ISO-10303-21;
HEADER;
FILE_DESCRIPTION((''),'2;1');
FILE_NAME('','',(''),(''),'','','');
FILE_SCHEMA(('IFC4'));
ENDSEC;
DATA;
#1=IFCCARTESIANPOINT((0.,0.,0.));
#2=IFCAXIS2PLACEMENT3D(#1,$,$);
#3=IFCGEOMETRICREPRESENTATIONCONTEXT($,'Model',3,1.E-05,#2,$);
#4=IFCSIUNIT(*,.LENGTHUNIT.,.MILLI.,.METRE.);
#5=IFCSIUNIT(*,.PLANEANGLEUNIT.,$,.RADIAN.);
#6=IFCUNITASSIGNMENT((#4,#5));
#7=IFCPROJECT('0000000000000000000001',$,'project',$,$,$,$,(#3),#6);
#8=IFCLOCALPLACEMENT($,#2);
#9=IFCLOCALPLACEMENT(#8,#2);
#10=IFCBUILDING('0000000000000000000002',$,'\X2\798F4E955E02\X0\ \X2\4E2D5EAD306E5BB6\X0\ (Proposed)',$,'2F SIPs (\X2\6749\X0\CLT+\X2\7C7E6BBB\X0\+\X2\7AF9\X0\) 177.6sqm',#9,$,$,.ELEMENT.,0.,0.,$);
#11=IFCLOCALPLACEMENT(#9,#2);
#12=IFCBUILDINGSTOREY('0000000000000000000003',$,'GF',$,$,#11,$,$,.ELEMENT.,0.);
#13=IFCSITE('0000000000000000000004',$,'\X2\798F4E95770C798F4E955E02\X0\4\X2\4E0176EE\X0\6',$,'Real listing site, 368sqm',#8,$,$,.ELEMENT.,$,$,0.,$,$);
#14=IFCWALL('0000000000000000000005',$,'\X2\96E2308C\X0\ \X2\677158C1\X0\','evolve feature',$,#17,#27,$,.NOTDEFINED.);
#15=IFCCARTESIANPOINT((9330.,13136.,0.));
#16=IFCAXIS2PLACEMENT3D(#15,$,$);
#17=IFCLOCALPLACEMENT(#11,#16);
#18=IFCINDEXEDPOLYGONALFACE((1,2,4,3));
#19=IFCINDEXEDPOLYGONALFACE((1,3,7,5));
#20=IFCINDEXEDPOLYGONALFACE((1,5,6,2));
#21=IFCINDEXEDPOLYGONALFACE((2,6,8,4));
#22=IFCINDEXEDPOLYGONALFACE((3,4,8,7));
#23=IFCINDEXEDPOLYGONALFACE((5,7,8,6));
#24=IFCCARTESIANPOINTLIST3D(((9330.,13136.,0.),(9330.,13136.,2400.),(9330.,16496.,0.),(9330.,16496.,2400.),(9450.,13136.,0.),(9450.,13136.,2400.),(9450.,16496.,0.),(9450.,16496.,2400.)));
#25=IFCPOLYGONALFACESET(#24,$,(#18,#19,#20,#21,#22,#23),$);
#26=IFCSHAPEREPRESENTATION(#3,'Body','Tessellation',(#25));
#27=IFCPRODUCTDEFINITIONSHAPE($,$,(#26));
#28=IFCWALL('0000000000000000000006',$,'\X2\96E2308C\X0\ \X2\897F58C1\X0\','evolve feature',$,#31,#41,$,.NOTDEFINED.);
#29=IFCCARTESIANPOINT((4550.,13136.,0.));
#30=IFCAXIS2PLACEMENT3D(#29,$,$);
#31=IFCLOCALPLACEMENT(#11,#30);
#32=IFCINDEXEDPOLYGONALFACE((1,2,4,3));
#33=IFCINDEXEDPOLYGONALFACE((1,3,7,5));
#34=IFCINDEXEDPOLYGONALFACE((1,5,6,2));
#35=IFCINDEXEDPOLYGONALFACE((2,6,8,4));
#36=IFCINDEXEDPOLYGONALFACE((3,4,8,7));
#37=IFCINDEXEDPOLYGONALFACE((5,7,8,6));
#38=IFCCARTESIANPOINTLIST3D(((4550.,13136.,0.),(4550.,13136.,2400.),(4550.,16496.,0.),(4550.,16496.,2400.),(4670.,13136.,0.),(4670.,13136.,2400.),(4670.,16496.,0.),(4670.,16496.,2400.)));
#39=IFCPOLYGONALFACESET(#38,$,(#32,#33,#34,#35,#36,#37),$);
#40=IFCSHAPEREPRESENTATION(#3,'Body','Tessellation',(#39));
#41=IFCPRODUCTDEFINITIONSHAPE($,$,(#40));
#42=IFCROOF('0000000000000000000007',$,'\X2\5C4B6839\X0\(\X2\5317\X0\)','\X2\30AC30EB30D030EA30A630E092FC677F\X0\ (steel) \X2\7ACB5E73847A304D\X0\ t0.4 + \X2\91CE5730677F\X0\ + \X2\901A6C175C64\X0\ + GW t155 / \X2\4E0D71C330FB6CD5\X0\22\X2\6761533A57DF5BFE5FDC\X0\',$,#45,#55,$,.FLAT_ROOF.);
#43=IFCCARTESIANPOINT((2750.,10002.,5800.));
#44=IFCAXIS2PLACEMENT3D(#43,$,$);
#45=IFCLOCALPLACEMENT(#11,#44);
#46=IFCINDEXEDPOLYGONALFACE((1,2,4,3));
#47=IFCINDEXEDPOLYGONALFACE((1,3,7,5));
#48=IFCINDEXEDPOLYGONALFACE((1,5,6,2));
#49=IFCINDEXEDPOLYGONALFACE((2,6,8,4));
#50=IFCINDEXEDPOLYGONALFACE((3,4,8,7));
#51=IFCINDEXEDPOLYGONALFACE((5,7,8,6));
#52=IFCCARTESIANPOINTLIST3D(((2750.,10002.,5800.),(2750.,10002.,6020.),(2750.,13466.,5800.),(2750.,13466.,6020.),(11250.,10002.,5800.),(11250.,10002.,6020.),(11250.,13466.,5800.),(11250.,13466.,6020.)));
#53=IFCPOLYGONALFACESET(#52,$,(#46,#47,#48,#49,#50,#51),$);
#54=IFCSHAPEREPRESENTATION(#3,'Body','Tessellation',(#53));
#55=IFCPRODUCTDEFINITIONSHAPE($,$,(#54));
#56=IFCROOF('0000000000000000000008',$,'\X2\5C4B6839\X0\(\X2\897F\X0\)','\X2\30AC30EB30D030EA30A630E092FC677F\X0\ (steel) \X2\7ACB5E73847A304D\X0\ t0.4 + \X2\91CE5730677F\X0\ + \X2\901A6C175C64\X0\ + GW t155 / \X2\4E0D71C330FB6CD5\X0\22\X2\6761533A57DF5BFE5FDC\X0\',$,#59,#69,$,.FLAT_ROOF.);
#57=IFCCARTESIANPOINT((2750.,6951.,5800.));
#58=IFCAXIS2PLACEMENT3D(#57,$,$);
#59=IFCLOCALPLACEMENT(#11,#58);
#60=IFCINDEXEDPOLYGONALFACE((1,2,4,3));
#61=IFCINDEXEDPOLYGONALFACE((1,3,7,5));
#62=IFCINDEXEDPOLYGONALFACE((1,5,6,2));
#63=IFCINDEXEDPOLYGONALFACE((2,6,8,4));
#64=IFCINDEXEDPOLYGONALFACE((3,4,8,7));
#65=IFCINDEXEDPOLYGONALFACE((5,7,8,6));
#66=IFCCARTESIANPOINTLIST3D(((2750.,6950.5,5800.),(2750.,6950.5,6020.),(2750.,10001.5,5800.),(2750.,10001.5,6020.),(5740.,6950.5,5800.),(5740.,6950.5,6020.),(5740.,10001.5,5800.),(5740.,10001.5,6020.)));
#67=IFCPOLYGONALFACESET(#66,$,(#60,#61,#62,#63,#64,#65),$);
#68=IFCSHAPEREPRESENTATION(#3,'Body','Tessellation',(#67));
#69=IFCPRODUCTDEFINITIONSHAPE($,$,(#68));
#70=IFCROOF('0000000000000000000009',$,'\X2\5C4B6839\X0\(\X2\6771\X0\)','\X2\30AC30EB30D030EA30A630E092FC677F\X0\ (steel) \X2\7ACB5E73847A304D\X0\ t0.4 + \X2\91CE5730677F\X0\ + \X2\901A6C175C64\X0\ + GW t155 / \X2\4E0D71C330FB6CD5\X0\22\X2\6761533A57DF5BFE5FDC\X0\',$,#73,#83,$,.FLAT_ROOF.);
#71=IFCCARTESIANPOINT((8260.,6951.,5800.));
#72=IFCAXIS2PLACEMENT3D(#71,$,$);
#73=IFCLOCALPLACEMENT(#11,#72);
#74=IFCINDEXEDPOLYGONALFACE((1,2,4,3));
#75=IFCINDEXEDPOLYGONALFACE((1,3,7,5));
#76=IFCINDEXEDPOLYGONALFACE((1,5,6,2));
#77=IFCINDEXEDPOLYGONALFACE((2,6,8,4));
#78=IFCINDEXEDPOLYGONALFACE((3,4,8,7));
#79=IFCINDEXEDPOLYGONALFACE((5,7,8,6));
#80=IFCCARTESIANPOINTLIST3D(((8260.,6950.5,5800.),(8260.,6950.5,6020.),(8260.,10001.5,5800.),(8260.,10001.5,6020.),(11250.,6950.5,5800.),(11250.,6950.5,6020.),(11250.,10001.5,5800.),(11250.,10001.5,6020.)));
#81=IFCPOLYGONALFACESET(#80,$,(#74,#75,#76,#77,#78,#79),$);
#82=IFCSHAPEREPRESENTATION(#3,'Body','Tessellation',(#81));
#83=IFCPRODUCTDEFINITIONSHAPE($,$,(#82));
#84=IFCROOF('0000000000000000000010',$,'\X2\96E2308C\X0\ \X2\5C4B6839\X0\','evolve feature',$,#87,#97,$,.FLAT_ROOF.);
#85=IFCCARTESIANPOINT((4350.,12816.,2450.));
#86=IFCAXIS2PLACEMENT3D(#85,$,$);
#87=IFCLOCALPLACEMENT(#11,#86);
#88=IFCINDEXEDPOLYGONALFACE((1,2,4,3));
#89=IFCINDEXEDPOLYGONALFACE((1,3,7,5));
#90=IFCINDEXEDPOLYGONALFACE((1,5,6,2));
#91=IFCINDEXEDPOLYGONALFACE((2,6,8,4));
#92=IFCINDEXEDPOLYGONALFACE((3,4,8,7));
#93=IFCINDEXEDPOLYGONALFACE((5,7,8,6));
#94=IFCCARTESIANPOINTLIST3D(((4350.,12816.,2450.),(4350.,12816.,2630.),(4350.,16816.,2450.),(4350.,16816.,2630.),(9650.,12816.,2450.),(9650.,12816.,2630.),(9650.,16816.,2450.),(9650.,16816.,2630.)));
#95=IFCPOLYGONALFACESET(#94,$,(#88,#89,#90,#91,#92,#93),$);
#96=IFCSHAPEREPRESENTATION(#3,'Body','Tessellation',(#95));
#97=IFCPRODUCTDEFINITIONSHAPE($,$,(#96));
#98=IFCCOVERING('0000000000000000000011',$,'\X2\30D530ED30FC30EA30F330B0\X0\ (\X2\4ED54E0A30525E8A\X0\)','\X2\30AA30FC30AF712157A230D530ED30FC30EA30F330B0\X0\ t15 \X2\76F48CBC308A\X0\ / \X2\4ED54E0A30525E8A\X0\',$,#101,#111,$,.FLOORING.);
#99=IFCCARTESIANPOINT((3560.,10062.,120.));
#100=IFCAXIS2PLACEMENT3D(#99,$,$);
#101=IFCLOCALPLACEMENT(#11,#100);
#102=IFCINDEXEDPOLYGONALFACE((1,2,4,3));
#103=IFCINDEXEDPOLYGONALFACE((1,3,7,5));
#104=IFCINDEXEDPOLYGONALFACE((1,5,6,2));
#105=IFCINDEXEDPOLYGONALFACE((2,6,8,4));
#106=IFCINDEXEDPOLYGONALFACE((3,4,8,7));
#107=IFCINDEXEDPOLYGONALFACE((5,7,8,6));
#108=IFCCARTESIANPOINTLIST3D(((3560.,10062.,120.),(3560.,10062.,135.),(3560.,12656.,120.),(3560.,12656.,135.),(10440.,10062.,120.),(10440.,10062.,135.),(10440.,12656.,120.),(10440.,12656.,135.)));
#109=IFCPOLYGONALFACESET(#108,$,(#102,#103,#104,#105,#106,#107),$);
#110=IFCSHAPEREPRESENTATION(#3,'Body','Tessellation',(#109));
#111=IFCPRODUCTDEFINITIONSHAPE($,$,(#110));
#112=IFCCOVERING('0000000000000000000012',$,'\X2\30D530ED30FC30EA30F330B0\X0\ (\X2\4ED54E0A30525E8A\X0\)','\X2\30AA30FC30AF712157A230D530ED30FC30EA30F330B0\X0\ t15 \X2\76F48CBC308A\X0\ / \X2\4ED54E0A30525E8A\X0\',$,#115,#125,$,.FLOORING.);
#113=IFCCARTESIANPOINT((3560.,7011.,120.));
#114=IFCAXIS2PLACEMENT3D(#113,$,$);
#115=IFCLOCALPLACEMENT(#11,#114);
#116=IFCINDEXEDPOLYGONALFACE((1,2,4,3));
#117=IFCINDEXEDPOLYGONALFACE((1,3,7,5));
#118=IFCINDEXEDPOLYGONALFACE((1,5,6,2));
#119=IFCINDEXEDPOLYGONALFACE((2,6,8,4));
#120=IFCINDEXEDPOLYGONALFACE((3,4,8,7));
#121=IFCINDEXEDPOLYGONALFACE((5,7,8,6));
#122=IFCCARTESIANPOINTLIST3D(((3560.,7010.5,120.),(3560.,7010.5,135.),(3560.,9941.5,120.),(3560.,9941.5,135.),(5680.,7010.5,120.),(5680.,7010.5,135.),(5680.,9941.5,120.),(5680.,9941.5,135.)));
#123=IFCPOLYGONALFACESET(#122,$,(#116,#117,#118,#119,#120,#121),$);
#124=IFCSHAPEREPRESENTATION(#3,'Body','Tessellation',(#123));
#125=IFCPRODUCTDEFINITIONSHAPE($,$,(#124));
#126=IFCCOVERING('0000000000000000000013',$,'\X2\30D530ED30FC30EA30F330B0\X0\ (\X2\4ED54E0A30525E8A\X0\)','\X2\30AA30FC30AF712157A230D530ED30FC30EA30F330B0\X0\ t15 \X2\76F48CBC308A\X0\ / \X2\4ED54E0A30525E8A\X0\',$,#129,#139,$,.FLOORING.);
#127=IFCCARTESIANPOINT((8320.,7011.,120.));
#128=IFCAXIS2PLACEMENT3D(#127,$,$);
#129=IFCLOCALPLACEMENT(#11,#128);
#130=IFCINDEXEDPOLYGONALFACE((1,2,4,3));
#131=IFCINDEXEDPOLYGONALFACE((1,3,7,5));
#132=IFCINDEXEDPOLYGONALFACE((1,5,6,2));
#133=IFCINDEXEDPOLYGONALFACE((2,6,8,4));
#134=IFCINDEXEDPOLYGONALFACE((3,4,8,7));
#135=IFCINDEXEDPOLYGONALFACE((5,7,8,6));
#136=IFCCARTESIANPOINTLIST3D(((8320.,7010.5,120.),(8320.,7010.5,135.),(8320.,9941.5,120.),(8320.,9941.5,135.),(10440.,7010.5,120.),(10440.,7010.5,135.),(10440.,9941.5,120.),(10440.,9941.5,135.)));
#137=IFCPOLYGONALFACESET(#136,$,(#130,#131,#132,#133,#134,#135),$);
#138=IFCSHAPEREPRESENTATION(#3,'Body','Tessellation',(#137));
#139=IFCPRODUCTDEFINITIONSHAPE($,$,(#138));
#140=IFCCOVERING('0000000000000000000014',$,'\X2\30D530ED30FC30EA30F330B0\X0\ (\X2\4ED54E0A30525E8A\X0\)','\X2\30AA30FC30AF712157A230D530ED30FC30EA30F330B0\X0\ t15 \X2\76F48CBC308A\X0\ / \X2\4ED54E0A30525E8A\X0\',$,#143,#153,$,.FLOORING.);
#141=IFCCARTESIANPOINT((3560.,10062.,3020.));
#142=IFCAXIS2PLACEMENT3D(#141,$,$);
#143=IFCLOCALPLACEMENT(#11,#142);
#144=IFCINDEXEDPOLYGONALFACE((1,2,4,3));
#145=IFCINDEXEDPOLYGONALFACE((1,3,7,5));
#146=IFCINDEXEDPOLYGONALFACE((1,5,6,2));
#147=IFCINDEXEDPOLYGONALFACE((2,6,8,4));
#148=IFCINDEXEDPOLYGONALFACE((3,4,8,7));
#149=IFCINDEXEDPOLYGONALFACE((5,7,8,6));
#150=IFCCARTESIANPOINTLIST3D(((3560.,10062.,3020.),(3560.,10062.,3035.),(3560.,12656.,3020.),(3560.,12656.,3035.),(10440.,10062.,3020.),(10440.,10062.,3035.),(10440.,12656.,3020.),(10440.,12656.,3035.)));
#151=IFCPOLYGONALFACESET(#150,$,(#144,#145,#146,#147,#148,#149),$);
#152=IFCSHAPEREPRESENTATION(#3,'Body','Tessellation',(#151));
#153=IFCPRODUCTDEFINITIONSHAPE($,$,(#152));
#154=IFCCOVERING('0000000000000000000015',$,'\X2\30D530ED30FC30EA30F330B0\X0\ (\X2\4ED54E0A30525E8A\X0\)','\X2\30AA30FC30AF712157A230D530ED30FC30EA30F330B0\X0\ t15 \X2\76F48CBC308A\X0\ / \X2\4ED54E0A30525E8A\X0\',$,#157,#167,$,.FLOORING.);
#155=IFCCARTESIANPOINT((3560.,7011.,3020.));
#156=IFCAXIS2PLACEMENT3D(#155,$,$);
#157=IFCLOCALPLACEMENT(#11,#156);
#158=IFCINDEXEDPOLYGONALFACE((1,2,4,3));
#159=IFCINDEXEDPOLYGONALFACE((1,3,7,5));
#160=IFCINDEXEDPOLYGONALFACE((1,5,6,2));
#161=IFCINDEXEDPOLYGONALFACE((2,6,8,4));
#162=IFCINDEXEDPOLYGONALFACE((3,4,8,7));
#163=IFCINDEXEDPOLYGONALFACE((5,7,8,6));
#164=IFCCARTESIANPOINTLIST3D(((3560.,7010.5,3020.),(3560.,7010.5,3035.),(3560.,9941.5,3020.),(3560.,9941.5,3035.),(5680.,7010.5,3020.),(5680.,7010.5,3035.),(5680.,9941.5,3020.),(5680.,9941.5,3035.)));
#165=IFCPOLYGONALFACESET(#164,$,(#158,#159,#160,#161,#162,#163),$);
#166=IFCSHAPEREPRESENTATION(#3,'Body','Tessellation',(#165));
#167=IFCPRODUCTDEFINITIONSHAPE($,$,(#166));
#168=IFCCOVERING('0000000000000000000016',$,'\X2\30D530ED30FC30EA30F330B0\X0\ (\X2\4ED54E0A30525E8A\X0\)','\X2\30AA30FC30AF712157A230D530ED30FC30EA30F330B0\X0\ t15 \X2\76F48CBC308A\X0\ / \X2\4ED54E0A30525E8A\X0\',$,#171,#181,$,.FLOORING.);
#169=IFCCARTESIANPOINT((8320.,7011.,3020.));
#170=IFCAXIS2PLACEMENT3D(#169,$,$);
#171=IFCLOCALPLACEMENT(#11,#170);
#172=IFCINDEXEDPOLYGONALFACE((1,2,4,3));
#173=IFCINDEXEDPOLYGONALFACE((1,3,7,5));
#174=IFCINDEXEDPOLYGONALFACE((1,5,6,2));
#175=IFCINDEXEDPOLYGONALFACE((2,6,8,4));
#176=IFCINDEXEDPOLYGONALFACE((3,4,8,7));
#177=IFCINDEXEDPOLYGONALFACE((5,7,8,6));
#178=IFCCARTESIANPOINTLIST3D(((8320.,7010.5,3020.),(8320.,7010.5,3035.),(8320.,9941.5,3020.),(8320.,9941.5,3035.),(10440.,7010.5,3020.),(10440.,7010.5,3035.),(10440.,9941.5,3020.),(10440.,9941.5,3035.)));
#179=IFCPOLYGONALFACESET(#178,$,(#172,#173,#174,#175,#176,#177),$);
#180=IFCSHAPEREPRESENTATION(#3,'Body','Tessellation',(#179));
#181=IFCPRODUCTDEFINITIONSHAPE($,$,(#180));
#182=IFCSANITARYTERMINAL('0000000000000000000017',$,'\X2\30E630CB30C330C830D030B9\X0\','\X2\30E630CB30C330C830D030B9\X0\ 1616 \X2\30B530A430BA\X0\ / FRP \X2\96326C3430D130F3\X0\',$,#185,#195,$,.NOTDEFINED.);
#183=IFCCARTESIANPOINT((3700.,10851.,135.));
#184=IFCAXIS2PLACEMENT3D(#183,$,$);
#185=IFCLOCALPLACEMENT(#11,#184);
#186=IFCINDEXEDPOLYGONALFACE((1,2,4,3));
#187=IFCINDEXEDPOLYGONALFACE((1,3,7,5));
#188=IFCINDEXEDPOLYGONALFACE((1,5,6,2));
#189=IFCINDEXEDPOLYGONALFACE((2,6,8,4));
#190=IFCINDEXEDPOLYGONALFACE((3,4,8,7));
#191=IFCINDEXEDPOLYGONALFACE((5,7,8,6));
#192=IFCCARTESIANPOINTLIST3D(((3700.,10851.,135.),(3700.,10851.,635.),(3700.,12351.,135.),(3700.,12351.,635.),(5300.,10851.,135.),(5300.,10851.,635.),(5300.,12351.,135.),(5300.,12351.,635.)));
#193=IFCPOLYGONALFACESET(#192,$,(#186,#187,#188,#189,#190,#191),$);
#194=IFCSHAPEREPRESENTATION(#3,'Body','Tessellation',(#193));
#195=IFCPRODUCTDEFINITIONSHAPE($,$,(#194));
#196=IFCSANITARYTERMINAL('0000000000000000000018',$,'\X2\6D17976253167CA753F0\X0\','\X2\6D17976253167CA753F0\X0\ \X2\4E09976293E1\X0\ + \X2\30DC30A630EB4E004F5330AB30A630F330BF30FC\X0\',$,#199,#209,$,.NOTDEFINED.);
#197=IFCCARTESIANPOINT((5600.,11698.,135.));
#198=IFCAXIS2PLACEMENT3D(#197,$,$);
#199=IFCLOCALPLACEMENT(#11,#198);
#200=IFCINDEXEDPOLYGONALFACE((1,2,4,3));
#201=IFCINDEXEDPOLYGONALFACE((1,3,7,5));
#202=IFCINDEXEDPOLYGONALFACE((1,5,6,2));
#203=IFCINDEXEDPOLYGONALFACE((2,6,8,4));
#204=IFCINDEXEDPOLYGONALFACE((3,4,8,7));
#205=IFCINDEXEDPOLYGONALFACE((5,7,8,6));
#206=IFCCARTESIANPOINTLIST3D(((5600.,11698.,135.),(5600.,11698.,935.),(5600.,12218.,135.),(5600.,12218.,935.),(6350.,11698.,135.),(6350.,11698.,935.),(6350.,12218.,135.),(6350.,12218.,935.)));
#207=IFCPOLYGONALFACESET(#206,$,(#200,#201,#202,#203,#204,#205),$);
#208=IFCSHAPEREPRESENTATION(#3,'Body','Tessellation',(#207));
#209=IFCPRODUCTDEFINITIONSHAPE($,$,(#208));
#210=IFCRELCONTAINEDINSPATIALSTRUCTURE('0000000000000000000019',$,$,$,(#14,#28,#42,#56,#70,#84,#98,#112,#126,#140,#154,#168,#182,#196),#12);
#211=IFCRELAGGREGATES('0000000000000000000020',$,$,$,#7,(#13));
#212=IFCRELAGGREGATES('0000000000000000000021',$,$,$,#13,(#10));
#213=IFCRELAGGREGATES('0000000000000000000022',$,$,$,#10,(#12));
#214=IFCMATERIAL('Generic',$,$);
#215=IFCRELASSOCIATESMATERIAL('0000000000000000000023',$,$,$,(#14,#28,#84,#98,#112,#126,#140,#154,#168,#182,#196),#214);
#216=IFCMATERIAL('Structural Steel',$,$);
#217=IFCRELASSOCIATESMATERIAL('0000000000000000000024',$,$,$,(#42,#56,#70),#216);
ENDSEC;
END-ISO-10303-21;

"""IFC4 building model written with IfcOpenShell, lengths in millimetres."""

from ifc_helpers import new_model, si_unit, frame, frame_2d, origin, place, context, project, spatial, rectangle, extrude, material, element, save


model = new_model("IFC4")

# Units and contexts
model_context = context("Model", 3, precision=1e-05, world=origin())
ifc_project = project(units=[si_unit("LENGTHUNIT", "METRE", prefix="MILLI"), si_unit("PLANEANGLEUNIT", "RADIAN")], contexts=[model_context])

# Site, building, storey
site_placement = place(None, origin())
site = spatial("IfcSite", under=ifc_project, at=site_placement, Name="福井県福井市4丁目6", ObjectType="Real listing site, 368sqm", CompositionType="ELEMENT", RefElevation=0.0)
building_placement = place(site_placement, origin())
building = spatial("IfcBuilding", under=site, at=building_placement, Name="福井市 中庭の家 (Proposed)", ObjectType="2F SIPs (杉CLT+籾殻+竹) 177.6sqm", CompositionType="ELEMENT", ElevationOfRefHeight=0.0, ElevationOfTerrain=0.0)
storey_placement = place(building_placement, origin())
storey = spatial("IfcBuildingStorey", under=building, at=storey_placement, Name="GF", CompositionType="ELEMENT", Elevation=0.0)

# Shared definitions
ifc_material_1 = material(Name="Generic")

# Walls
wall_1_placement = place(storey_placement, frame((9330.0, 13136.0, 0.0)))
element("IfcWall", 1, at=wall_1_placement, inside=storey, material=ifc_material_1, Name="離れ 東壁", Description="evolve feature", PredefinedType="NOTDEFINED", context=model_context, shape_type="SweptSolid", body=[
    extrude(rectangle(XDim=120.0, YDim=3360.0, at=frame_2d((60.0, 1680.0))), frame((9330.0, 13136.0, 0.0)), (0.0, 0.0, 1.0), 2400.0),
])
wall_2_placement = place(storey_placement, frame((4550.0, 13136.0, 0.0)))
element("IfcWall", 2, at=wall_2_placement, inside=storey, material=ifc_material_1, Name="離れ 西壁", Description="evolve feature", PredefinedType="NOTDEFINED", context=model_context, shape_type="SweptSolid", body=[
    extrude(rectangle(XDim=120.0, YDim=3360.0, at=frame_2d((60.0, 1680.0))), frame((4550.0, 13136.0, 0.0)), (0.0, 0.0, 1.0), 2400.0),
])

# Roofs
ifc_material_2 = material(Name="Structural Steel")
for number, where, name in (
    (3, (2750.0, 10002.0, 5800.0), "屋根(北)"),
):
    element("IfcRoof", number, at=place(storey_placement, frame(where)), inside=storey, material=ifc_material_2, Name=name, Description="ガルバリウム鋼板 (steel) 立平葺き t0.4 + 野地板 + 通気層 + GW t155 / 不燃・法22条区域対応", PredefinedType="FLAT_ROOF", context=model_context, shape_type="SweptSolid", body=[
        extrude(rectangle(XDim=8500.0, YDim=3464.0, at=frame_2d((4250.0, 1732.0))), frame((2750.0, 10002.0, 5800.0)), (0.0, 0.0, 1.0), 220.0),
    ])
roof_1_placement = place(storey_placement, frame((2750.0, 6951.0, 5800.0)))
element("IfcRoof", 4, at=roof_1_placement, inside=storey, material=ifc_material_2, Name="屋根(西)", Description="ガルバリウム鋼板 (steel) 立平葺き t0.4 + 野地板 + 通気層 + GW t155 / 不燃・法22条区域対応", PredefinedType="FLAT_ROOF", context=model_context, shape_type="SweptSolid", body=[
    extrude(rectangle(XDim=2990.0, YDim=3051.0, at=frame_2d((1495.0, 1525.0))), frame((2750.0, 6951.0, 5800.0)), (0.0, 0.0, 1.0), 220.0),
])
roof_2_placement = place(storey_placement, frame((8260.0, 6951.0, 5800.0)))
element("IfcRoof", 5, at=roof_2_placement, inside=storey, material=ifc_material_2, Name="屋根(東)", Description="ガルバリウム鋼板 (steel) 立平葺き t0.4 + 野地板 + 通気層 + GW t155 / 不燃・法22条区域対応", PredefinedType="FLAT_ROOF", context=model_context, shape_type="SweptSolid", body=[
    extrude(rectangle(XDim=2990.0, YDim=3051.0, at=frame_2d((1495.0, 1525.0))), frame((8260.0, 6951.0, 5800.0)), (0.0, 0.0, 1.0), 220.0),
])
roof_3_placement = place(storey_placement, frame((4350.0, 12816.0, 2450.0)))
element("IfcRoof", 6, at=roof_3_placement, inside=storey, material=ifc_material_1, Name="離れ 屋根", Description="evolve feature", PredefinedType="FLAT_ROOF", context=model_context, shape_type="SweptSolid", body=[
    extrude(rectangle(XDim=5300.0, YDim=4000.0, at=frame_2d((2650.0, 2000.0))), frame((4350.0, 12816.0, 2450.0)), (0.0, 0.0, 1.0), 180.0),
])

# Coverings
covering_1_placement = place(storey_placement, frame((3560.0, 10062.0, 120.0)))
element("IfcCovering", 7, at=covering_1_placement, inside=storey, material=ifc_material_1, Name="フローリング (仕上げ床)", Description="オーク無垢フローリング t15 直貼り / 仕上げ床", PredefinedType="FLOORING", context=model_context, shape_type="SweptSolid", body=[
    extrude(rectangle(XDim=6880.0, YDim=2594.0, at=frame_2d((3440.0, 1297.0))), frame((3560.0, 10062.0, 120.0)), (0.0, 0.0, 1.0), 15.0),
])
covering_2_placement = place(storey_placement, frame((3560.0, 7011.0, 120.0)))
element("IfcCovering", 8, at=covering_2_placement, inside=storey, material=ifc_material_1, Name="フローリング (仕上げ床)", Description="オーク無垢フローリング t15 直貼り / 仕上げ床", PredefinedType="FLOORING", context=model_context, shape_type="SweptSolid", body=[
    extrude(rectangle(XDim=2120.0, YDim=2931.0, at=frame_2d((1060.0, 1465.0))), frame((3560.0, 7011.0, 120.0)), (0.0, 0.0, 1.0), 15.0),
])
covering_3_placement = place(storey_placement, frame((8320.0, 7011.0, 120.0)))
element("IfcCovering", 9, at=covering_3_placement, inside=storey, material=ifc_material_1, Name="フローリング (仕上げ床)", Description="オーク無垢フローリング t15 直貼り / 仕上げ床", PredefinedType="FLOORING", context=model_context, shape_type="SweptSolid", body=[
    extrude(rectangle(XDim=2120.0, YDim=2931.0, at=frame_2d((1060.0, 1465.0))), frame((8320.0, 7011.0, 120.0)), (0.0, 0.0, 1.0), 15.0),
])
covering_4_placement = place(storey_placement, frame((3560.0, 10062.0, 3020.0)))
element("IfcCovering", 10, at=covering_4_placement, inside=storey, material=ifc_material_1, Name="フローリング (仕上げ床)", Description="オーク無垢フローリング t15 直貼り / 仕上げ床", PredefinedType="FLOORING", context=model_context, shape_type="SweptSolid", body=[
    extrude(rectangle(XDim=6880.0, YDim=2594.0, at=frame_2d((3440.0, 1297.0))), frame((3560.0, 10062.0, 3020.0)), (0.0, 0.0, 1.0), 15.0),
])
covering_5_placement = place(storey_placement, frame((3560.0, 7011.0, 3020.0)))
element("IfcCovering", 11, at=covering_5_placement, inside=storey, material=ifc_material_1, Name="フローリング (仕上げ床)", Description="オーク無垢フローリング t15 直貼り / 仕上げ床", PredefinedType="FLOORING", context=model_context, shape_type="SweptSolid", body=[
    extrude(rectangle(XDim=2120.0, YDim=2931.0, at=frame_2d((1060.0, 1465.0))), frame((3560.0, 7011.0, 3020.0)), (0.0, 0.0, 1.0), 15.0),
])
covering_6_placement = place(storey_placement, frame((8320.0, 7011.0, 3020.0)))
element("IfcCovering", 12, at=covering_6_placement, inside=storey, material=ifc_material_1, Name="フローリング (仕上げ床)", Description="オーク無垢フローリング t15 直貼り / 仕上げ床", PredefinedType="FLOORING", context=model_context, shape_type="SweptSolid", body=[
    extrude(rectangle(XDim=2120.0, YDim=2931.0, at=frame_2d((1060.0, 1465.0))), frame((8320.0, 7011.0, 3020.0)), (0.0, 0.0, 1.0), 15.0),
])

# Sanitary terminals
sanitary_terminal_1_placement = place(storey_placement, frame((3700.0, 10851.0, 135.0)))
element("IfcSanitaryTerminal", 13, at=sanitary_terminal_1_placement, inside=storey, material=ifc_material_1, Name="ユニットバス", Description="ユニットバス 1616 サイズ / FRP 防水パン", PredefinedType="NOTDEFINED", context=model_context, shape_type="SweptSolid", body=[
    extrude(rectangle(XDim=1600.0, YDim=1500.0, at=frame_2d((800.0, 750.0))), frame((3700.0, 10851.0, 135.0)), (0.0, 0.0, 1.0), 500.0),
])
sanitary_terminal_2_placement = place(storey_placement, frame((5600.0, 11698.0, 135.0)))
element("IfcSanitaryTerminal", 14, at=sanitary_terminal_2_placement, inside=storey, material=ifc_material_1, Name="洗面化粧台", Description="洗面化粧台 三面鏡 + ボウル一体カウンター", PredefinedType="NOTDEFINED", context=model_context, shape_type="SweptSolid", body=[
    extrude(rectangle(XDim=750.0, YDim=520.0, at=frame_2d((375.0, 260.0))), frame((5600.0, 11698.0, 135.0)), (0.0, 0.0, 1.0), 800.0),
])

save(model, "model.ifc")
